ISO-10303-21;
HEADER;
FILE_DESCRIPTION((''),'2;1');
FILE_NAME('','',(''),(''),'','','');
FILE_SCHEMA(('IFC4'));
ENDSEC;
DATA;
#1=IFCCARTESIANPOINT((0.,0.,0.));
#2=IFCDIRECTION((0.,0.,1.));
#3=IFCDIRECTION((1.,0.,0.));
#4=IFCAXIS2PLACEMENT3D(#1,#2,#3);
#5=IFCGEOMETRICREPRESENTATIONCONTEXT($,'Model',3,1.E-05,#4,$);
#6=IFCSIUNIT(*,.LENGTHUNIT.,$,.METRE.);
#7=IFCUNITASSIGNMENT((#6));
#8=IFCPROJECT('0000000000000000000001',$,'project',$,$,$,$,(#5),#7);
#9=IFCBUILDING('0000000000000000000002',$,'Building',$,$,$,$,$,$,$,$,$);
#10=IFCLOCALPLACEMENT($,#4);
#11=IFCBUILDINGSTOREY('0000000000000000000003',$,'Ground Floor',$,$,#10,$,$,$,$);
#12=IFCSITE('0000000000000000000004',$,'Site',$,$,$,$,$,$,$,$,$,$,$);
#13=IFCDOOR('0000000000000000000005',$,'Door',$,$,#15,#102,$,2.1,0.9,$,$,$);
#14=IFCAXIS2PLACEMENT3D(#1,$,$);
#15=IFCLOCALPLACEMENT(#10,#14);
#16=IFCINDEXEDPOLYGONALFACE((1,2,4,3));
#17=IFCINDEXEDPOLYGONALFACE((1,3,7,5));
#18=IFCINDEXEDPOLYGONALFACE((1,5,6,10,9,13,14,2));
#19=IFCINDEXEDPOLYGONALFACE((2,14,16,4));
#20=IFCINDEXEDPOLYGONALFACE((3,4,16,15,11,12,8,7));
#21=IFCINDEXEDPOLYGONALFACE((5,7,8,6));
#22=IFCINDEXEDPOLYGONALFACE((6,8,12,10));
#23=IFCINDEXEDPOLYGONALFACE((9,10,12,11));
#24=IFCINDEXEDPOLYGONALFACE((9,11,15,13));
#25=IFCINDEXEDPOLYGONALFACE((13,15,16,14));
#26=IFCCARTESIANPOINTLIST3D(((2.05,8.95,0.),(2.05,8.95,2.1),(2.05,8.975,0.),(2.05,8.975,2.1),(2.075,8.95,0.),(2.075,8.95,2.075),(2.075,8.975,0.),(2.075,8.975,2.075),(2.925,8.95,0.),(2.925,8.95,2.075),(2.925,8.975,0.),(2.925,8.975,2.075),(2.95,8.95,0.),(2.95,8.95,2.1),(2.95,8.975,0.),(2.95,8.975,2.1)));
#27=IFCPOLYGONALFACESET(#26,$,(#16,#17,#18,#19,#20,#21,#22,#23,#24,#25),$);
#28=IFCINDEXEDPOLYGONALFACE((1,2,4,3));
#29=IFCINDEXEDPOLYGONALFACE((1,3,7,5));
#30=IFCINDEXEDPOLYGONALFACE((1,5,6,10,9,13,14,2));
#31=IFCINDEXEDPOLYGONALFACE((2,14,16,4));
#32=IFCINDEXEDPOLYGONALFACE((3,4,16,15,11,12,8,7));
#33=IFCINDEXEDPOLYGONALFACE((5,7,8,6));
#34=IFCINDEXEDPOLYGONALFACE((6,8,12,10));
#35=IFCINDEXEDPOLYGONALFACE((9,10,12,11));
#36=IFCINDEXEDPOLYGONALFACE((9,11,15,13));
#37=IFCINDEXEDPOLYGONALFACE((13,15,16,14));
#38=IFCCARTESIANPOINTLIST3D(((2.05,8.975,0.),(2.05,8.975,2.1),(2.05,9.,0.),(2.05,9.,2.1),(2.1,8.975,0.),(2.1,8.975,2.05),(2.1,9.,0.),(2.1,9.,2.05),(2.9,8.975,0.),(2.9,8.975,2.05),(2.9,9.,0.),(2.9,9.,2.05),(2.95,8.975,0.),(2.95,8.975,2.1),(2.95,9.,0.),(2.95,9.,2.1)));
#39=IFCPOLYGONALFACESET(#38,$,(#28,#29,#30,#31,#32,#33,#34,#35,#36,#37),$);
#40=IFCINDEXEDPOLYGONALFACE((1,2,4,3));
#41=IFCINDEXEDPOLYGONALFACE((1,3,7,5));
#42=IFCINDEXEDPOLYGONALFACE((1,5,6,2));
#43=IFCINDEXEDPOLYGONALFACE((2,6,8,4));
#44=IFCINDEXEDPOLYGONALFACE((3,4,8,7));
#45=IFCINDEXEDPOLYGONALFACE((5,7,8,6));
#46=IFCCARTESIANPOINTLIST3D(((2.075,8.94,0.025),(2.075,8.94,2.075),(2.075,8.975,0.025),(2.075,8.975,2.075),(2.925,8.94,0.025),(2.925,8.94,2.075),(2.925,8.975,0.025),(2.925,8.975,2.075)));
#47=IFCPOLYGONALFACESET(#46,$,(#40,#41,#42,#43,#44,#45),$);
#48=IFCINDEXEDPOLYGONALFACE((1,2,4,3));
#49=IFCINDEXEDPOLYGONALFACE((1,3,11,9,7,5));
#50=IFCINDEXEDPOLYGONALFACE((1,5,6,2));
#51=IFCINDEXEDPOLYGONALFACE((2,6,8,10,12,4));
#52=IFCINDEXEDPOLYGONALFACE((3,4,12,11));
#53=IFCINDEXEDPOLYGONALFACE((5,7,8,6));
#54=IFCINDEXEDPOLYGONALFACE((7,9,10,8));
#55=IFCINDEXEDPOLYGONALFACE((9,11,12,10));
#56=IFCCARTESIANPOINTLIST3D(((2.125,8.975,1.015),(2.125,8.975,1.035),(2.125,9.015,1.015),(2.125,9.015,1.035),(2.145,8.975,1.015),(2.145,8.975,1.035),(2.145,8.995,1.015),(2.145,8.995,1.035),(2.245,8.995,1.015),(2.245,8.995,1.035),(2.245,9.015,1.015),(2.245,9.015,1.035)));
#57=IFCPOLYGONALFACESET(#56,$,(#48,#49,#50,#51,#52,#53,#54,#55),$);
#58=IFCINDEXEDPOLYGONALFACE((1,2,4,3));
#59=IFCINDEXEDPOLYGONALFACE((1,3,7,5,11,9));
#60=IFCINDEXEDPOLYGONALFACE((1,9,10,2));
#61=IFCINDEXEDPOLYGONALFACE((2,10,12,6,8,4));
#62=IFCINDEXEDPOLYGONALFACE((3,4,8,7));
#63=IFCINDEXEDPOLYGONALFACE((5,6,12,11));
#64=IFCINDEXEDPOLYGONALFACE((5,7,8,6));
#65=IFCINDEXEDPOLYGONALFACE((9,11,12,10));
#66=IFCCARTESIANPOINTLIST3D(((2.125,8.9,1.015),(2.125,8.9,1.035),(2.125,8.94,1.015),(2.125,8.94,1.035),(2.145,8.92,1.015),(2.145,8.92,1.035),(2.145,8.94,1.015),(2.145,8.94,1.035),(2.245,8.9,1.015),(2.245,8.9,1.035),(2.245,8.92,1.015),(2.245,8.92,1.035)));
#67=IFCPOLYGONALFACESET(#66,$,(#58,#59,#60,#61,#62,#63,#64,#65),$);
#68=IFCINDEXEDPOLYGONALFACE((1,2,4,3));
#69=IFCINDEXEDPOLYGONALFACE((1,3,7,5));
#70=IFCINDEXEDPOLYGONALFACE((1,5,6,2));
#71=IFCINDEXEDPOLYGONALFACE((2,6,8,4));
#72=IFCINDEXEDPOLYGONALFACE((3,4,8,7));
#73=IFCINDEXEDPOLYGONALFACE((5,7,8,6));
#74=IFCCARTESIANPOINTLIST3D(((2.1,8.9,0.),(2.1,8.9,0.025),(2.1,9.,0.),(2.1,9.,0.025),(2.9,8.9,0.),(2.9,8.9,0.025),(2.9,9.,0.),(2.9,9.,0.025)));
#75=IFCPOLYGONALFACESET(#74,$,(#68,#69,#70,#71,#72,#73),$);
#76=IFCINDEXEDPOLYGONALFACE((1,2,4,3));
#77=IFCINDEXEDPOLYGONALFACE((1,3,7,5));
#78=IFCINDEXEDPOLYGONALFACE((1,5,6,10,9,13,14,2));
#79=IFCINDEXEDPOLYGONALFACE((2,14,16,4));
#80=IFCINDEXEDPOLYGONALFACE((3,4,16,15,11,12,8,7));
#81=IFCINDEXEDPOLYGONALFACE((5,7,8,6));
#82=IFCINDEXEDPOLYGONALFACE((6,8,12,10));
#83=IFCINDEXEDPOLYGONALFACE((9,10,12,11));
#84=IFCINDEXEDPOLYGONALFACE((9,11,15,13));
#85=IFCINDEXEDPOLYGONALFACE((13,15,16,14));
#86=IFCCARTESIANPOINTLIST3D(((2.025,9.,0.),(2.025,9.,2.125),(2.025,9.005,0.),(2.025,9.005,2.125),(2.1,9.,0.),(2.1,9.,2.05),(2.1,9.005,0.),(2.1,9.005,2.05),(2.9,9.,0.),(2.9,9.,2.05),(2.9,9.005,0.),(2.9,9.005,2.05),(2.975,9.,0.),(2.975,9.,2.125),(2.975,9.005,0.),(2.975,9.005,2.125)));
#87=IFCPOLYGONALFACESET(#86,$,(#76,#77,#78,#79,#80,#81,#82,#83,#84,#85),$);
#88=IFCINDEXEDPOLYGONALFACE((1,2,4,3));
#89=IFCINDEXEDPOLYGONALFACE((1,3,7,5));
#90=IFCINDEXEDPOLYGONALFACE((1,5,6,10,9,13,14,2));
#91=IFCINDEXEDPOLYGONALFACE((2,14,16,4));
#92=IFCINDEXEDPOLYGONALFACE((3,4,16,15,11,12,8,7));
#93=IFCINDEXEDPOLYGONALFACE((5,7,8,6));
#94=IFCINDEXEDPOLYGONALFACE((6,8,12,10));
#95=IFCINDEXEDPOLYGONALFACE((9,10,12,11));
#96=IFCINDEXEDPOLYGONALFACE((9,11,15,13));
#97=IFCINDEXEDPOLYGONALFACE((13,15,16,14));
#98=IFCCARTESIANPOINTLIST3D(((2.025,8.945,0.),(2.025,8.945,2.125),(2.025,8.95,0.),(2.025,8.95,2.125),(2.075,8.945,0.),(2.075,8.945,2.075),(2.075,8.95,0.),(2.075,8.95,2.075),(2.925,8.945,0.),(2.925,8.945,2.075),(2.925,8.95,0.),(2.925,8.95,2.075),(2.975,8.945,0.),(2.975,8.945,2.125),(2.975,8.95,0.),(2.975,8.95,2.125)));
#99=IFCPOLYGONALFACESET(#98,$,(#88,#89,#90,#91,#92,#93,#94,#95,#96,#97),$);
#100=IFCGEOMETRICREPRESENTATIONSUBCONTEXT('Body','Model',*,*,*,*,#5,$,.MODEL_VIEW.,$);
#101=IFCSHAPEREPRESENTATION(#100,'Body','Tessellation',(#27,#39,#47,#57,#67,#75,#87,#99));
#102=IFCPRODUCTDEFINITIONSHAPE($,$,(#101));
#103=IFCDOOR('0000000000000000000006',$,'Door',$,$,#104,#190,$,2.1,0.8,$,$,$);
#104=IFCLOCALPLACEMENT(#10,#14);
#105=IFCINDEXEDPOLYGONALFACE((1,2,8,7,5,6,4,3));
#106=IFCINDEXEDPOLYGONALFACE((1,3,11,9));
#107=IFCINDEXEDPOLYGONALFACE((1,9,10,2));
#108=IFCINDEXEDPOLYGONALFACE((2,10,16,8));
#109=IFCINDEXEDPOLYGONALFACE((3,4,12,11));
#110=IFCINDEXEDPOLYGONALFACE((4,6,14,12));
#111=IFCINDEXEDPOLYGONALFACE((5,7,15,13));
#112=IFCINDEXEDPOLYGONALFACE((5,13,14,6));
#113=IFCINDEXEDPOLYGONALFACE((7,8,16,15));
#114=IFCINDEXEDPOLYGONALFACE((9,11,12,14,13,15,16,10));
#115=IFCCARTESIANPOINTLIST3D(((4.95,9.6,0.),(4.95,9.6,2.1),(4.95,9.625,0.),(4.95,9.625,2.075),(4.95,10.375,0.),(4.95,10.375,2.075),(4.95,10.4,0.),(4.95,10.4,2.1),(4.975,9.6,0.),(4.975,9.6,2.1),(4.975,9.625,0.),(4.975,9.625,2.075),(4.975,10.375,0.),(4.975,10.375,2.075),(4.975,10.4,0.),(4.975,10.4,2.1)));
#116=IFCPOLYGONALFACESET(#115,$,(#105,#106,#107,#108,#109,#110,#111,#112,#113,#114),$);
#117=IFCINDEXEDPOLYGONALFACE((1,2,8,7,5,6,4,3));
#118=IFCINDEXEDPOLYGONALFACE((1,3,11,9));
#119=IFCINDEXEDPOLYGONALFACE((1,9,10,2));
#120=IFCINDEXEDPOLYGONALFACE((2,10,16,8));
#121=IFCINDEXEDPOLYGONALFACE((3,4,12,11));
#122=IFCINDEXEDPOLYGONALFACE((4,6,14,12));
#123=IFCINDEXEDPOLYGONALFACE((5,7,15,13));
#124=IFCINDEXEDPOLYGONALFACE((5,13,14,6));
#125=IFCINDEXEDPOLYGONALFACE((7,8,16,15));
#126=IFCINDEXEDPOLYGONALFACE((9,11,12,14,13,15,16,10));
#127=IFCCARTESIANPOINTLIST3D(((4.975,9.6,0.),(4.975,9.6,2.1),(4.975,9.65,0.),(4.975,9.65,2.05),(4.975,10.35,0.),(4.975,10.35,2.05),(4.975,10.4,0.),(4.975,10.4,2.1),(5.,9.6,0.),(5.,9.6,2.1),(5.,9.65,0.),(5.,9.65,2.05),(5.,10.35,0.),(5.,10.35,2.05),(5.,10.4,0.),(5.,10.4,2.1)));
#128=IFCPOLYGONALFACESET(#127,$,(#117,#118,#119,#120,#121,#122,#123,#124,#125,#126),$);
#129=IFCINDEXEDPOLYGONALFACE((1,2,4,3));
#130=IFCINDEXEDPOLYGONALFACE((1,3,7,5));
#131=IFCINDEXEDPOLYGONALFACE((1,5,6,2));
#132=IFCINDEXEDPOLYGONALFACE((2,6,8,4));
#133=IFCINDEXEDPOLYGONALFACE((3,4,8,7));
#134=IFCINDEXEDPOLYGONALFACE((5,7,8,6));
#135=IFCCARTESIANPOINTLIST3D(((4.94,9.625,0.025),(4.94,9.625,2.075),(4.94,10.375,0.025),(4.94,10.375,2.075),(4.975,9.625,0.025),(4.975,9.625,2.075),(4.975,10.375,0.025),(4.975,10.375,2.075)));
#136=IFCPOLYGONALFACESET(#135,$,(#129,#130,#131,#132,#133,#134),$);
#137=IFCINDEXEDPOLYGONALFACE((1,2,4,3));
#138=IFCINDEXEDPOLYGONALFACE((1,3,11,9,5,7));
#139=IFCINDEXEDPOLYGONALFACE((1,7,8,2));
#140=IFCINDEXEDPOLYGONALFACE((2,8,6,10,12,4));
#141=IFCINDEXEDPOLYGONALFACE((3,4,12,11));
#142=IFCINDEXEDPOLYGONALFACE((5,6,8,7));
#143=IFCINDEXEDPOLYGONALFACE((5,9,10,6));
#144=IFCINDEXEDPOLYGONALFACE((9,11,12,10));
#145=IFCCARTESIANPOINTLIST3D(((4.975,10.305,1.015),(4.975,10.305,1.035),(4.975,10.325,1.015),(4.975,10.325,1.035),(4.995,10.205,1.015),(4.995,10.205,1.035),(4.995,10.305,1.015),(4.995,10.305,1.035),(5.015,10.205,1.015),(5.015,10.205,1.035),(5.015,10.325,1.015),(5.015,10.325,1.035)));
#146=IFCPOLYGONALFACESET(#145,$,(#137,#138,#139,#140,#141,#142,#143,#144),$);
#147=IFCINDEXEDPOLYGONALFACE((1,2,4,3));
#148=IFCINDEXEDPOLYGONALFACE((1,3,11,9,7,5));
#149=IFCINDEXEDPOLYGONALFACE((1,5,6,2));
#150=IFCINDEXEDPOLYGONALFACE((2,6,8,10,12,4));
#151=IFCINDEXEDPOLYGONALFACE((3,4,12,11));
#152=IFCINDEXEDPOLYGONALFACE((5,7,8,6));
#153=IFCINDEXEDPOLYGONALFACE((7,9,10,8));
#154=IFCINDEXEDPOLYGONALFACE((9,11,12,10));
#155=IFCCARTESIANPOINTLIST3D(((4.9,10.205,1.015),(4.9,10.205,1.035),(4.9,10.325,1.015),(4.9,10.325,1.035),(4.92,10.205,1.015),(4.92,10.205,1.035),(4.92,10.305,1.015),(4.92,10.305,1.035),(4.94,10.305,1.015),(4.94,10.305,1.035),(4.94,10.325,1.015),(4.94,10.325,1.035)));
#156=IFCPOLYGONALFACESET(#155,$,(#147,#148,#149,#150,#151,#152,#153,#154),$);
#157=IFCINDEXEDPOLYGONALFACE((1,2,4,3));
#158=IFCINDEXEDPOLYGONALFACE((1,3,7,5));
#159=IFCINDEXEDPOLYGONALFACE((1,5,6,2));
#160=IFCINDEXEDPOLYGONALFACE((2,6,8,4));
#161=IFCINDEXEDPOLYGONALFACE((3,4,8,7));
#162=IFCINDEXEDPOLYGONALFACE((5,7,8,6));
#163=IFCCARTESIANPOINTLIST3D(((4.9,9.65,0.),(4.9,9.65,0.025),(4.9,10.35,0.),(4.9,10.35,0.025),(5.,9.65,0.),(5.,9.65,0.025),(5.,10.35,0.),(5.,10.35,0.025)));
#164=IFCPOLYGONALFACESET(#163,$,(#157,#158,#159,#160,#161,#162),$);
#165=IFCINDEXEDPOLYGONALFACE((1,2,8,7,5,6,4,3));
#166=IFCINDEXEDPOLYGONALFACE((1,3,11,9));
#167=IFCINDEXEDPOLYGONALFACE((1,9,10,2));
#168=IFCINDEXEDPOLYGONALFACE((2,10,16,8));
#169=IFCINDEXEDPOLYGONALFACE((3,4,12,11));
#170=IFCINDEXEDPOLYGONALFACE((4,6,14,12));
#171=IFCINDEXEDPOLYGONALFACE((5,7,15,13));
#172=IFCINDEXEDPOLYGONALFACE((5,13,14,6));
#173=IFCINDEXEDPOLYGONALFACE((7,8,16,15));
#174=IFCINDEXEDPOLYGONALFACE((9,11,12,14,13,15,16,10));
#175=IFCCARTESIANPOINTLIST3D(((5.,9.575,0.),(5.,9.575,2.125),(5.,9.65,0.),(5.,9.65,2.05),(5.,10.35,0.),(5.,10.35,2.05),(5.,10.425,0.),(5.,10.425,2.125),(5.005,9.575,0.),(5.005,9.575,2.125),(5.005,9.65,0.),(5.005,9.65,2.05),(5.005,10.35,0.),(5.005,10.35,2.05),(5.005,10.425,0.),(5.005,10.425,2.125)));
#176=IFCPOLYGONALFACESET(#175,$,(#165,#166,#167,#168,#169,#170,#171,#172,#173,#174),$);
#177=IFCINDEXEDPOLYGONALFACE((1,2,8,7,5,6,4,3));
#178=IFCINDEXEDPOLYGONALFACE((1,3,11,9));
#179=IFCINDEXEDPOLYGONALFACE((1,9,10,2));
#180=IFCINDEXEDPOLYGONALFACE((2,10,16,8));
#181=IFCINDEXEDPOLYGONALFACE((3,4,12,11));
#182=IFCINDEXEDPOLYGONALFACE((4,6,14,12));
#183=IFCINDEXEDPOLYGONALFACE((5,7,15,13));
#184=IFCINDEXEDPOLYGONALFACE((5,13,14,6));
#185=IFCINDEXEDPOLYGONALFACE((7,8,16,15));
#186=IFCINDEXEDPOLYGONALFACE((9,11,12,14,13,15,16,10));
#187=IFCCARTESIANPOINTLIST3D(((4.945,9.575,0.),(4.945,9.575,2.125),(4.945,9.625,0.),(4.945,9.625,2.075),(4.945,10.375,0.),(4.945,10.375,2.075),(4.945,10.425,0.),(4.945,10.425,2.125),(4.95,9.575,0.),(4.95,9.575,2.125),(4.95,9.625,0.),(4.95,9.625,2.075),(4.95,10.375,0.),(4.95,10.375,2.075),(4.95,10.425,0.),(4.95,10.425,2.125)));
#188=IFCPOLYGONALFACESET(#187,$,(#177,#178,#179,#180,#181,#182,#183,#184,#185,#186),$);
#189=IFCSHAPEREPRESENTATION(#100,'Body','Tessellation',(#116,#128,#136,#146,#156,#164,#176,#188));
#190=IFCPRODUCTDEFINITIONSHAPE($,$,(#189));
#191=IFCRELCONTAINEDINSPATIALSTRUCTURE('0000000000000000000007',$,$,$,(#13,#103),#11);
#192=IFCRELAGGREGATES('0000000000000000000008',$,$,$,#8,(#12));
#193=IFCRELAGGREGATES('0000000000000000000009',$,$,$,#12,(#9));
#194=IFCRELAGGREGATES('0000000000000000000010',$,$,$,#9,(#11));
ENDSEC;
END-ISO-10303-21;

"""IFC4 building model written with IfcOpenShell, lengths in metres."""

from ifc_helpers import new_model, si_unit, frame, origin_with_axes, place, context, subcontext, project, spatial, line, indexed_curve, outline, extrude, element, save


model = new_model("IFC4")

# Units and contexts
model_context = context("Model", 3, precision=1e-05, world=origin_with_axes())
body_context = subcontext(model_context, "Body", "Model", "MODEL_VIEW")
ifc_project = project(units=[si_unit("LENGTHUNIT", "METRE")], contexts=[model_context])

# Site, building, storey
site = spatial("IfcSite", under=ifc_project, Name="Site")
building = spatial("IfcBuilding", under=site, Name="Building")
storey_placement = place(None, origin_with_axes())
storey = spatial("IfcBuildingStorey", under=building, at=storey_placement, Name="Ground Floor")

# Doors
door_1_placement = place(storey_placement, frame((2.95, 9.0, 0.0), z_axis=(0.0, 0.0, 1.0), x_axis=(-1.0, 0.0, 0.0)))
element("IfcDoor", 1, at=door_1_placement, inside=storey, Name="Door", OverallHeight=2.1, OverallWidth=0.9, context=body_context, shape_type="SweptSolid", body=[
    extrude(outline(indexed_curve([(0.0, 0.0), (0.0, 2.1), (0.9, 2.1), (0.9, 0.0), (0.875, 0.0), (0.875, 2.075), (0.025, 2.075), (0.025, 0.0)], segments=[line(1, 2, 3, 4, 5, 6, 7, 8, 1)])), frame((0.0, 0.025, 0.0), z_axis=(0.0, -1.0, 0.0), x_axis=(1.0, 0.0, 0.0)), (0.0, 0.0, -1.0), 0.025),
    extrude(outline(indexed_curve([(0.0, 0.0), (0.0, 2.1), (0.9, 2.1), (0.9, 0.0), (0.85, 0.0), (0.85, 2.05), (0.05, 2.05), (0.05, 0.0)], segments=[line(1, 2, 3, 4, 5, 6, 7, 8, 1)])), frame((0.0, 0.0, 0.0), z_axis=(0.0, -1.0, 0.0), x_axis=(1.0, 0.0, 0.0)), (0.0, 0.0, -1.0), 0.025),
    extrude(outline(indexed_curve([(0.0, 0.0), (0.85, 0.0), (0.85, 0.035), (0.0, 0.035)], segments=[line(1, 2, 3, 4, 1)])), frame((0.025, 0.025, 0.025), z_axis=(0.0, 0.0, 1.0), x_axis=(1.0, 0.0, 0.0)), (0.0, 0.0, 1.0), 2.05),
    extrude(outline(indexed_curve([(0.0, 0.0), (0.0, -0.04), (-0.12, -0.04), (-0.12, -0.02), (-0.02, -0.02), (-0.02, 0.0)], segments=[line(1, 2, 3, 4, 5, 6, 1)])), frame((0.825, 0.025, 1.015), z_axis=(0.0, 0.0, 1.0), x_axis=(1.0, 0.0, 0.0)), (0.0, 0.0, 1.0), 0.02),
    extrude(outline(indexed_curve([(0.0, 0.0), (0.0, 0.04), (-0.12, 0.04), (-0.12, 0.02), (-0.02, 0.02), (-0.02, 0.0)], segments=[line(1, 2, 3, 4, 5, 6, 1)])), frame((0.825, 0.06, 1.015), z_axis=(0.0, 0.0, 1.0), x_axis=(1.0, 0.0, 0.0)), (0.0, 0.0, 1.0), 0.02),
    extrude(outline(indexed_curve([(0.0, 0.0), (0.8, 0.0), (0.8, 0.1), (0.0, 0.1)], segments=[line(1, 2, 3, 4, 1)])), frame((0.05, 0.0, 0.0), z_axis=(0.0, 0.0, 1.0), x_axis=(1.0, 0.0, 0.0)), (0.0, 0.0, 1.0), 0.025),
    extrude(outline(indexed_curve([(0.0, 0.0), (0.0, 2.125), (0.95, 2.125), (0.95, 0.0), (0.875, 0.0), (0.875, 2.05), (0.075, 2.05), (0.075, 0.0)], segments=[line(1, 2, 3, 4, 5, 6, 7, 8, 1)])), frame((-0.025, -0.005, 0.0), z_axis=(0.0, -1.0, 0.0), x_axis=(1.0, 0.0, 0.0)), (0.0, 0.0, -1.0), 0.005),
    extrude(outline(indexed_curve([(0.0, 0.0), (0.0, 2.125), (0.95, 2.125), (0.95, 0.0), (0.9, 0.0), (0.9, 2.075), (0.05, 2.075), (0.05, 0.0)], segments=[line(1, 2, 3, 4, 5, 6, 7, 8, 1)])), frame((-0.025, 0.05, 0.0), z_axis=(0.0, -1.0, 0.0), x_axis=(1.0, 0.0, 0.0)), (0.0, 0.0, -1.0), 0.005),
])
door_2_placement = place(storey_placement, frame((5.0, 9.6, 0.0), z_axis=(0.0, 0.0, 1.0), x_axis=(0.0, 1.0, 0.0)))
element("IfcDoor", 2, at=door_2_placement, inside=storey, Name="Door", OverallHeight=2.1, OverallWidth=0.8, context=body_context, shape_type="SweptSolid", body=[
    extrude(outline(indexed_curve([(0.0, 0.0), (0.0, 2.1), (0.8, 2.1), (0.8, 0.0), (0.775, 0.0), (0.775, 2.075), (0.025, 2.075), (0.025, 0.0)], segments=[line(1, 2, 3, 4, 5, 6, 7, 8, 1)])), frame((0.0, 0.025, 0.0), z_axis=(0.0, -1.0, 0.0), x_axis=(1.0, 0.0, 0.0)), (0.0, 0.0, -1.0), 0.025),
    extrude(outline(indexed_curve([(0.0, 0.0), (0.0, 2.1), (0.8, 2.1), (0.8, 0.0), (0.75, 0.0), (0.75, 2.05), (0.05, 2.05), (0.05, 0.0)], segments=[line(1, 2, 3, 4, 5, 6, 7, 8, 1)])), frame((0.0, 0.0, 0.0), z_axis=(0.0, -1.0, 0.0), x_axis=(1.0, 0.0, 0.0)), (0.0, 0.0, -1.0), 0.025),
    extrude(outline(indexed_curve([(0.0, 0.0), (0.75, 0.0), (0.75, 0.035), (0.0, 0.035)], segments=[line(1, 2, 3, 4, 1)])), frame((0.025, 0.025, 0.025), z_axis=(0.0, 0.0, 1.0), x_axis=(1.0, 0.0, 0.0)), (0.0, 0.0, 1.0), 2.05),
    extrude(outline(indexed_curve([(0.0, 0.0), (0.0, -0.04), (-0.12, -0.04), (-0.12, -0.02), (-0.02, -0.02), (-0.02, 0.0)], segments=[line(1, 2, 3, 4, 5, 6, 1)])), frame((0.725, 0.025, 1.015), z_axis=(0.0, 0.0, 1.0), x_axis=(1.0, 0.0, 0.0)), (0.0, 0.0, 1.0), 0.02),
    extrude(outline(indexed_curve([(0.0, 0.0), (0.0, 0.04), (-0.12, 0.04), (-0.12, 0.02), (-0.02, 0.02), (-0.02, 0.0)], segments=[line(1, 2, 3, 4, 5, 6, 1)])), frame((0.725, 0.06, 1.015), z_axis=(0.0, 0.0, 1.0), x_axis=(1.0, 0.0, 0.0)), (0.0, 0.0, 1.0), 0.02),
    extrude(outline(indexed_curve([(0.0, 0.0), (0.7, 0.0), (0.7, 0.1), (0.0, 0.1)], segments=[line(1, 2, 3, 4, 1)])), frame((0.05, 0.0, 0.0), z_axis=(0.0, 0.0, 1.0), x_axis=(1.0, 0.0, 0.0)), (0.0, 0.0, 1.0), 0.025),
    extrude(outline(indexed_curve([(0.0, 0.0), (0.0, 2.125), (0.85, 2.125), (0.85, 0.0), (0.775, 0.0), (0.775, 2.05), (0.075, 2.05), (0.075, 0.0)], segments=[line(1, 2, 3, 4, 5, 6, 7, 8, 1)])), frame((-0.025, -0.005, 0.0), z_axis=(0.0, -1.0, 0.0), x_axis=(1.0, 0.0, 0.0)), (0.0, 0.0, -1.0), 0.005),
    extrude(outline(indexed_curve([(0.0, 0.0), (0.0, 2.125), (0.85, 2.125), (0.85, 0.0), (0.8, 0.0), (0.8, 2.075), (0.05, 2.075), (0.05, 0.0)], segments=[line(1, 2, 3, 4, 5, 6, 7, 8, 1)])), frame((-0.025, 0.05, 0.0), z_axis=(0.0, -1.0, 0.0), x_axis=(1.0, 0.0, 0.0)), (0.0, 0.0, -1.0), 0.005),
])

save(model, "model.ifc")
